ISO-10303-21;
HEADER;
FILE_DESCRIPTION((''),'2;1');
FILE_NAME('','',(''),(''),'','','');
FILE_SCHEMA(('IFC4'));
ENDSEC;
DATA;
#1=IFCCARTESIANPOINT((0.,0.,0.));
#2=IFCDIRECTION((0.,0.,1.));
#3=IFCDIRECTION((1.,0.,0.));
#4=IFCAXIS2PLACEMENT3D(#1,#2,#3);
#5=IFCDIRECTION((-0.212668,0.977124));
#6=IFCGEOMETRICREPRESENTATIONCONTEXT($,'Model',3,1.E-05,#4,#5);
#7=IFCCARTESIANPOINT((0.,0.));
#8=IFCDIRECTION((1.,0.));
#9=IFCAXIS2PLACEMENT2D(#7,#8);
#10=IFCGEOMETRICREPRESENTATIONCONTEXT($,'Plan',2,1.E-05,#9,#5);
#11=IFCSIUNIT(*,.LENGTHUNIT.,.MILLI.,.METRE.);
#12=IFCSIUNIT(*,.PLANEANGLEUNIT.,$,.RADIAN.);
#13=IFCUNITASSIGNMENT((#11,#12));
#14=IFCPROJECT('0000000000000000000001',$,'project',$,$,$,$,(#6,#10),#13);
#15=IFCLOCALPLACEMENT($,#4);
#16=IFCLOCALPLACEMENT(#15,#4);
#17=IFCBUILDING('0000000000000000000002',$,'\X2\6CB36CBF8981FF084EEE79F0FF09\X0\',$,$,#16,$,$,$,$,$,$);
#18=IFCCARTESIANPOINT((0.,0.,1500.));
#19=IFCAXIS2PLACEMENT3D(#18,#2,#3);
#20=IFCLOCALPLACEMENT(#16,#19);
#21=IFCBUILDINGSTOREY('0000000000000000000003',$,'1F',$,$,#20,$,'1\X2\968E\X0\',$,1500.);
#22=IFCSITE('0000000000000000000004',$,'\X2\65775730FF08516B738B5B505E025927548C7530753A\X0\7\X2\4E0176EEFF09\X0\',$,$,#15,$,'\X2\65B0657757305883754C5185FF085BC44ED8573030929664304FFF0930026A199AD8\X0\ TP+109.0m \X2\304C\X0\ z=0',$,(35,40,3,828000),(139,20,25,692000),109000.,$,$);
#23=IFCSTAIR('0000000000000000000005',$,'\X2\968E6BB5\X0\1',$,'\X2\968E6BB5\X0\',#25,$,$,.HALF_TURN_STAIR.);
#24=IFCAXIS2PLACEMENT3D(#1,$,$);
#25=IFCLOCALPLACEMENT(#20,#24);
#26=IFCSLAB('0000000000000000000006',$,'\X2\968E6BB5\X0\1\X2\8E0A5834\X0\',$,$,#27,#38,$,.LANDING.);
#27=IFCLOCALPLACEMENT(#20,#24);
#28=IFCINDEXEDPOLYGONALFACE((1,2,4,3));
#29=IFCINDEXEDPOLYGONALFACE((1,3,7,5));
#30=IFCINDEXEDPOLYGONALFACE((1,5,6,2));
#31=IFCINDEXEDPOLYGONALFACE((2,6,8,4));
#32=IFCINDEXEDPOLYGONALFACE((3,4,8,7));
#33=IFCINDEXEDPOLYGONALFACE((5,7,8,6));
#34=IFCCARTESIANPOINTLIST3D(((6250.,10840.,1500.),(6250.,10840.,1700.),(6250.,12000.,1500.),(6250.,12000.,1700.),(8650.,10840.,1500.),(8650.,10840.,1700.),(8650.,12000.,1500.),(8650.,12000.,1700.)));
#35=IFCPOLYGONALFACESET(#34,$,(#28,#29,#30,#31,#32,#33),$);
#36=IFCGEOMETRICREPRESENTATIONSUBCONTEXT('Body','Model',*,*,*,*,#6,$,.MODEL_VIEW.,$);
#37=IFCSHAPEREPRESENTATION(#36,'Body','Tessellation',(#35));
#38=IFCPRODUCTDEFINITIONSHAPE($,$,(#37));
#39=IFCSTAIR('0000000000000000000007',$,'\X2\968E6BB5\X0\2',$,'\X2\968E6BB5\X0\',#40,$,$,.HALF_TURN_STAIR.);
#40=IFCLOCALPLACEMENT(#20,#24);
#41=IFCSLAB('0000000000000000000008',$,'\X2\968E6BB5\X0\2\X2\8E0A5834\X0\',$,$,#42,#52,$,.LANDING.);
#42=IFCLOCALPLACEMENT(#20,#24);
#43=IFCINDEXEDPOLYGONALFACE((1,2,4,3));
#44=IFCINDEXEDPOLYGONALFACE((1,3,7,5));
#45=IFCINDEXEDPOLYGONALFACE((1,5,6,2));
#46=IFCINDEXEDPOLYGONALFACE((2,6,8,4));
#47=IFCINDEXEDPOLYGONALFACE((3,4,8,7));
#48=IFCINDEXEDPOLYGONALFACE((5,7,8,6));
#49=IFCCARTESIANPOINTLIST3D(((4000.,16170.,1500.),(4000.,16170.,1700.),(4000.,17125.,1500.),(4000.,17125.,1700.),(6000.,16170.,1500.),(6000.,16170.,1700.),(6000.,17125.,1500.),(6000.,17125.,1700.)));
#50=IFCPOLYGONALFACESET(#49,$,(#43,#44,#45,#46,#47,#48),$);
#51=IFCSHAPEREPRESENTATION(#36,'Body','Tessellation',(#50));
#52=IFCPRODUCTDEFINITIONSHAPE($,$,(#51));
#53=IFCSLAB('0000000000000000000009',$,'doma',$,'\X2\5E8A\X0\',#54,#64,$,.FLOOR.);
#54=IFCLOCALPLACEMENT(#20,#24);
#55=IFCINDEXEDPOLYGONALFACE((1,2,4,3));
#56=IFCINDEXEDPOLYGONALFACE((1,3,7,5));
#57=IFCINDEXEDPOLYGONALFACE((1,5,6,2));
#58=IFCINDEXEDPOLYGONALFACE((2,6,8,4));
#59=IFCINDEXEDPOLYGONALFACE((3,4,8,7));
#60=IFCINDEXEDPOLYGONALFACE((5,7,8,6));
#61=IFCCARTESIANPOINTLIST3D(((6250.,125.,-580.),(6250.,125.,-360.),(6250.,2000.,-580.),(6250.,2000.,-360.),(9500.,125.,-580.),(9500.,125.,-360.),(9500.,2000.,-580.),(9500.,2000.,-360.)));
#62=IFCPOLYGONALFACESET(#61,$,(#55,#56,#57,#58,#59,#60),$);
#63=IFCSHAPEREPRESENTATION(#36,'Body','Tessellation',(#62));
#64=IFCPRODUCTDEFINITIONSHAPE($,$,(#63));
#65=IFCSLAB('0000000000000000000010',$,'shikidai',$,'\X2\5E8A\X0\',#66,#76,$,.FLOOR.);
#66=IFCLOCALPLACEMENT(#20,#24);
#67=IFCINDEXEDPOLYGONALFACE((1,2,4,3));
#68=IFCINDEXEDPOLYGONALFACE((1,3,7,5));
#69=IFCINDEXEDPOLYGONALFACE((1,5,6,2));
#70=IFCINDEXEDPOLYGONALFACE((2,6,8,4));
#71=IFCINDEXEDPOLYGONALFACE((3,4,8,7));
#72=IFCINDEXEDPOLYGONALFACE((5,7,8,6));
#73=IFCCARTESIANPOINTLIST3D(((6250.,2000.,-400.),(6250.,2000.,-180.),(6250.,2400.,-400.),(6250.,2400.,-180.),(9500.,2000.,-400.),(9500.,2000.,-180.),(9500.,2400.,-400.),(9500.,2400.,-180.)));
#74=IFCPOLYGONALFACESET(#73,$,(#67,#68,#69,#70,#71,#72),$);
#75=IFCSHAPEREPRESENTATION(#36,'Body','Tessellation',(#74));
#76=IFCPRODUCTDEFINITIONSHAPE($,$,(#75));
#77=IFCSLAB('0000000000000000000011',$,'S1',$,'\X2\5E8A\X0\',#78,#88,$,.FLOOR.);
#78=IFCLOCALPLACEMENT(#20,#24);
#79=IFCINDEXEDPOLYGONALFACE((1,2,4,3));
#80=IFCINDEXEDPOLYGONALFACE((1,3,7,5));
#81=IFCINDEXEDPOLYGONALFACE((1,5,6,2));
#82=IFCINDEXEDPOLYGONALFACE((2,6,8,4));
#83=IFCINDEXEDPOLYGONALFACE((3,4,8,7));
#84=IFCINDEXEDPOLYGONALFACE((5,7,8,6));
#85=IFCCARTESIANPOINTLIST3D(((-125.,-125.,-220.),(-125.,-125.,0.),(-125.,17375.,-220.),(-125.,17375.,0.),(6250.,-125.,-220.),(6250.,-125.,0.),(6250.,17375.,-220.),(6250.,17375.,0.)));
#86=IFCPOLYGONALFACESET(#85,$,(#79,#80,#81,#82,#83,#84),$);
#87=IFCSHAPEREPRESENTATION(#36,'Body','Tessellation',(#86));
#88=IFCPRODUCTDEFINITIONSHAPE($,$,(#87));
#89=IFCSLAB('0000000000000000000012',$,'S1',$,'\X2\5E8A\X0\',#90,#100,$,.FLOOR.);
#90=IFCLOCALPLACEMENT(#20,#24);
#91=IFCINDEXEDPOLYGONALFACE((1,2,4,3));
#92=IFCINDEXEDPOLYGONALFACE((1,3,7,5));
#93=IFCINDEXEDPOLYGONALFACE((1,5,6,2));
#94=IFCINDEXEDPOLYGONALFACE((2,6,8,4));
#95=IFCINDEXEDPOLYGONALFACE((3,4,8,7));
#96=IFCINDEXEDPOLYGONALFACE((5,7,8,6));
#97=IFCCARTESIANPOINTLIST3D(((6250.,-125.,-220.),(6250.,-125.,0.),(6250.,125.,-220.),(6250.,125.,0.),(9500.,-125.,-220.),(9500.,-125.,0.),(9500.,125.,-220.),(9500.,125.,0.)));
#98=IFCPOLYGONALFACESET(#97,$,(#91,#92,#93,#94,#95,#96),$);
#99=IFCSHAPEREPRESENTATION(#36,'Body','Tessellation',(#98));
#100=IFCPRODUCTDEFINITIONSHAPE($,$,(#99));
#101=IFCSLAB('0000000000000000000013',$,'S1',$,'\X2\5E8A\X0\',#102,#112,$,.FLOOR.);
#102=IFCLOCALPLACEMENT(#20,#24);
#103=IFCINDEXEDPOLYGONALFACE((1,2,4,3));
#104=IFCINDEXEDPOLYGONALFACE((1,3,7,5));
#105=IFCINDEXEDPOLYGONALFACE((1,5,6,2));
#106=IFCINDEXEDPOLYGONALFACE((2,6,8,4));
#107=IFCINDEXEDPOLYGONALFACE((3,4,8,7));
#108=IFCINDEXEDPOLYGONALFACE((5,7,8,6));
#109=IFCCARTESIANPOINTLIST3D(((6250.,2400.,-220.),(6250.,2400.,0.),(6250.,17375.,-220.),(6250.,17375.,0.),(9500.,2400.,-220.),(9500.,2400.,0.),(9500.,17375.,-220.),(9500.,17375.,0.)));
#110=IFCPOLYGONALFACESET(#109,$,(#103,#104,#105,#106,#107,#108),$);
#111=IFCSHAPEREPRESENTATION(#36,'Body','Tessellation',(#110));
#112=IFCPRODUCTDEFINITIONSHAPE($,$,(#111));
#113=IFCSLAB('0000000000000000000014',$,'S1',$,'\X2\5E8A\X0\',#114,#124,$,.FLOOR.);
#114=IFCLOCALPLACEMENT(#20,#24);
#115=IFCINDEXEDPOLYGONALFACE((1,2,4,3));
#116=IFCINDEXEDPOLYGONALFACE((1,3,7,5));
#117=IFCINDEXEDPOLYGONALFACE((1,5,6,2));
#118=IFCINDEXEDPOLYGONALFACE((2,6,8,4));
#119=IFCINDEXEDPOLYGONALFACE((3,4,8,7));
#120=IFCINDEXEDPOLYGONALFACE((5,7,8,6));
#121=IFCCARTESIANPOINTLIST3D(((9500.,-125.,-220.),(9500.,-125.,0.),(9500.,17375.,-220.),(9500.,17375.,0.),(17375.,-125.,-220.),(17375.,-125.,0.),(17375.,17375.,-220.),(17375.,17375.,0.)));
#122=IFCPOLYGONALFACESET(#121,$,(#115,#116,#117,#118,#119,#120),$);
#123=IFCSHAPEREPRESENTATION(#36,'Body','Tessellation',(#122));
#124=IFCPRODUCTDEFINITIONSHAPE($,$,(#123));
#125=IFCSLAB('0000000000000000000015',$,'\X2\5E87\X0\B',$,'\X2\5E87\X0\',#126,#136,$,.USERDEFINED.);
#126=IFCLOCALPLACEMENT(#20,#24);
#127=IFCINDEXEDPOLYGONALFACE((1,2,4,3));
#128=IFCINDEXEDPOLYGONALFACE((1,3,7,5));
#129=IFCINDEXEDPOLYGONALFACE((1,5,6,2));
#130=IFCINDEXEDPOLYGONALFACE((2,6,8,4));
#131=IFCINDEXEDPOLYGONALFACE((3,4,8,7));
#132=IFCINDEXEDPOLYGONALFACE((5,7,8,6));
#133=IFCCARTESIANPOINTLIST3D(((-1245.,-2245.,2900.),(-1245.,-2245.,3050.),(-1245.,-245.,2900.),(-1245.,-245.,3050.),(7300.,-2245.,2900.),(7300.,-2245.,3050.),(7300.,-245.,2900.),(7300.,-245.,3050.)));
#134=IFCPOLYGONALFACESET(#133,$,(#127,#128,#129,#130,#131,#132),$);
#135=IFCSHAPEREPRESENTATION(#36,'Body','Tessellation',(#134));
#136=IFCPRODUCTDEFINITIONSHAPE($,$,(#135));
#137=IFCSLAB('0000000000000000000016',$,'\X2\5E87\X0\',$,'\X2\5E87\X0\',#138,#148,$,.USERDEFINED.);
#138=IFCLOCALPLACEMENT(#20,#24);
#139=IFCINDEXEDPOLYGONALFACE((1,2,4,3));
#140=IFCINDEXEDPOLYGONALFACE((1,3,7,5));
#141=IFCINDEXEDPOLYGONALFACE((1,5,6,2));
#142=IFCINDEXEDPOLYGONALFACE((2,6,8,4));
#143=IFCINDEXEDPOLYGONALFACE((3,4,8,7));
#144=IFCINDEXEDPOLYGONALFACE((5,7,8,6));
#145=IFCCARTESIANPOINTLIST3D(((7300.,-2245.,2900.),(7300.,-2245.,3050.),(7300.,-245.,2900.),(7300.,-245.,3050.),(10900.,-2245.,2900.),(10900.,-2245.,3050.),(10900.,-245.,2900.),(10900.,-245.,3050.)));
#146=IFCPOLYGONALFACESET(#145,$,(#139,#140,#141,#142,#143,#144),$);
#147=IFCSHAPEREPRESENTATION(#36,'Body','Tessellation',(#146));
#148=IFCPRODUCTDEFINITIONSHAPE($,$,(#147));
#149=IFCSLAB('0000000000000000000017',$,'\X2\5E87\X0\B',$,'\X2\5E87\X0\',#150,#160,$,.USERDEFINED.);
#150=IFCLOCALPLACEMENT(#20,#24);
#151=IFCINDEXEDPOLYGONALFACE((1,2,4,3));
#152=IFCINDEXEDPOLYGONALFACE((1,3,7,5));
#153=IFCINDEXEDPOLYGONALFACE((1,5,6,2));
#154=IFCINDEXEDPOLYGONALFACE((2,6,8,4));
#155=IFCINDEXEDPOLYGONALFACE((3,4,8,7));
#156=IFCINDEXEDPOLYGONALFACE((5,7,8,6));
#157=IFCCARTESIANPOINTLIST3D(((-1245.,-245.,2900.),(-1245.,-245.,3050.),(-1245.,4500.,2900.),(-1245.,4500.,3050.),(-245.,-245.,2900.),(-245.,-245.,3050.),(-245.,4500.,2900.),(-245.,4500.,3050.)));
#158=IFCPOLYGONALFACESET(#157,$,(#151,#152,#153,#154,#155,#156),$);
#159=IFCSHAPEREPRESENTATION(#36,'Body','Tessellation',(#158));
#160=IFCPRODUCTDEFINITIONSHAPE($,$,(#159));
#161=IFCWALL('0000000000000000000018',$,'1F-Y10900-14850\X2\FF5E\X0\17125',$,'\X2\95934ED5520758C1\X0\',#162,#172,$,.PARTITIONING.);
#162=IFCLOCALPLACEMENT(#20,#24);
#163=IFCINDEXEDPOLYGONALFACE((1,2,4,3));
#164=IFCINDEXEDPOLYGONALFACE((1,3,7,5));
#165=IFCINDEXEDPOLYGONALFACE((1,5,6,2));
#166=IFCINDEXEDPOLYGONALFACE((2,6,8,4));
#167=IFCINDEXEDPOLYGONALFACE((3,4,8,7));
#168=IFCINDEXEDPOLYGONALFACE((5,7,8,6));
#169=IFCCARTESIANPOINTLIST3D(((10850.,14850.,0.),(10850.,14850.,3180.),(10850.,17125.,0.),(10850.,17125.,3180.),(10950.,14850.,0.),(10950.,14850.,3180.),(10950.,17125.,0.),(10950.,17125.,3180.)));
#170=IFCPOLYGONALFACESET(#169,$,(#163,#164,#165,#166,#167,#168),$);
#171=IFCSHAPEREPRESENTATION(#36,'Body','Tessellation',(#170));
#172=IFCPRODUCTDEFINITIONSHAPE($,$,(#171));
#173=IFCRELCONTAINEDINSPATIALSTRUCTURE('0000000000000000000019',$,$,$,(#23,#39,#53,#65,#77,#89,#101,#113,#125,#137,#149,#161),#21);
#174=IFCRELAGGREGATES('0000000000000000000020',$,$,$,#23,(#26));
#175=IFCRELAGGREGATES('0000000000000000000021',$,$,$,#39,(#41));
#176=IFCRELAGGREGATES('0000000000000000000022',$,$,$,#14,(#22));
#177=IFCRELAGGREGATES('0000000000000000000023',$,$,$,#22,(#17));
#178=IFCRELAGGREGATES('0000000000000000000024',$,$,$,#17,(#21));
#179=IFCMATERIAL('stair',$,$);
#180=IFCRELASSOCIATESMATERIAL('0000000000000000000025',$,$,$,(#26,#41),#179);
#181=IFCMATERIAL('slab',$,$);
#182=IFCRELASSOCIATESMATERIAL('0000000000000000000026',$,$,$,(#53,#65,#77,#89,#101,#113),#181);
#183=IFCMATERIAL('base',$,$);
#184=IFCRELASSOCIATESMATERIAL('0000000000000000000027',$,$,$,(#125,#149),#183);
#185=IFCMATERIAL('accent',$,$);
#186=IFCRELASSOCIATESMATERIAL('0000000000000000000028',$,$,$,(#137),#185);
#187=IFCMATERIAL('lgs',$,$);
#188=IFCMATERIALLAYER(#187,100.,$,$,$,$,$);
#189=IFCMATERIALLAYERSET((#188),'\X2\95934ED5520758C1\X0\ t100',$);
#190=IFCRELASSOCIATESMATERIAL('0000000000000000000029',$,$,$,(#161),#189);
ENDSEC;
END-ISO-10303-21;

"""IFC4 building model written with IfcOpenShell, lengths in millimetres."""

from ifc_helpers import new_model, si_unit, direction, frame, frame_2d, origin, origin_with_axes, origin_2d_with_axis, place, context, subcontext, project, spatial, rectangle, extrude, material, layer, layer_set, layer_usage, element, aggregate, save


model = new_model("IFC4")

# Units and contexts
model_context = context("Model", 3, precision=1e-05, world=origin_with_axes(), true_north=direction((-0.212668, 0.977124)))
plan_context = context("Plan", 2, precision=1e-05, world=origin_2d_with_axis(), true_north=direction((-0.212668, 0.977124)))
body_context = subcontext(model_context, "Body", "Model", "MODEL_VIEW")
ifc_project = project(units=[si_unit("LENGTHUNIT", "METRE", prefix="MILLI"), si_unit("PLANEANGLEUNIT", "RADIAN")], contexts=[model_context, plan_context])

# Site, building, storey
site_placement = place(None, origin_with_axes())
site = spatial("IfcSite", under=ifc_project, at=site_placement, Name="敷地（八王子市大和田町7丁目）", LongName="新敷地境界内（寄付地を除く）。標高 TP+109.0m が z=0", RefLatitude=(35, 40, 3, 828000), RefLongitude=(139, 20, 25, 692000), RefElevation=109000.0)
building_placement = place(site_placement, origin_with_axes())
building = spatial("IfcBuilding", under=site, at=building_placement, Name="河沿要（仮称）")
storey_placement = place(building_placement, frame((0.0, 0.0, 1500.0), z_axis=(0.0, 0.0, 1.0), x_axis=(1.0, 0.0, 0.0)))
storey = spatial("IfcBuildingStorey", under=building, at=storey_placement, Name="1F", LongName="1階", Elevation=1500.0)

# Stairs, slabs
stair_1_placement = place(storey_placement, origin_with_axes())
stair_1 = element("IfcStair", 1, at=stair_1_placement, inside=storey, Name="階段1", ObjectType="階段", PredefinedType="HALF_TURN_STAIR")
ifc_material_1 = material(Name="stair")
slab_1_placement = place(stair_1_placement, origin_with_axes())
slab_1 = element("IfcSlab", 2, at=slab_1_placement, material=ifc_material_1, Name="階段1踊場", PredefinedType="LANDING", context=body_context, shape_type="SweptSolid", body=[
    extrude(rectangle(XDim=2400.0, YDim=1160.0, at=frame_2d((7450.0, 11420.0))), frame((0.0, 0.0, 1500.0)), (0.0, 0.0, 1.0), 200.0),
])
stair_2_placement = place(storey_placement, origin_with_axes())
stair_2 = element("IfcStair", 3, at=stair_2_placement, inside=storey, Name="階段2", ObjectType="階段", PredefinedType="HALF_TURN_STAIR")
slab_2_placement = place(stair_2_placement, origin_with_axes())
slab_2 = element("IfcSlab", 4, at=slab_2_placement, material=ifc_material_1, Name="階段2踊場", PredefinedType="LANDING", context=body_context, shape_type="SweptSolid", body=[
    extrude(rectangle(XDim=2000.0, YDim=955.0, at=frame_2d((5000.0, 16647.5))), frame((0.0, 0.0, 1500.0)), (0.0, 0.0, 1.0), 200.0),
])

# Slabs
ifc_material_2 = material(Name="slab")
slab_3_placement = place(storey_placement, origin_with_axes())
element("IfcSlab", 5, at=slab_3_placement, inside=storey, material=ifc_material_2, Name="doma", ObjectType="床", PredefinedType="FLOOR", context=body_context, shape_type="SweptSolid", body=[
    extrude(rectangle(XDim=3250.0, YDim=1875.0, at=frame_2d((7875.0, 1062.5))), frame((0.0, 0.0, -580.0)), (0.0, 0.0, 1.0), 220.0),
])
slab_4_placement = place(storey_placement, origin_with_axes())
element("IfcSlab", 6, at=slab_4_placement, inside=storey, material=ifc_material_2, Name="shikidai", ObjectType="床", PredefinedType="FLOOR", context=body_context, shape_type="SweptSolid", body=[
    extrude(rectangle(XDim=3250.0, YDim=400.0, at=frame_2d((7875.0, 2200.0))), frame((0.0, 0.0, -400.0)), (0.0, 0.0, 1.0), 220.0),
])
slab_5_placement = place(storey_placement, origin_with_axes())
element("IfcSlab", 7, at=slab_5_placement, inside=storey, material=ifc_material_2, Name="S1", ObjectType="床", PredefinedType="FLOOR", context=body_context, shape_type="SweptSolid", body=[
    extrude(rectangle(XDim=6375.0, YDim=17500.0, at=frame_2d((3062.5, 8625.0))), frame((0.0, 0.0, -220.0)), (0.0, 0.0, 1.0), 220.0),
])
slab_6_placement = place(storey_placement, origin_with_axes())
element("IfcSlab", 8, at=slab_6_placement, inside=storey, material=ifc_material_2, Name="S1", ObjectType="床", PredefinedType="FLOOR", context=body_context, shape_type="SweptSolid", body=[
    extrude(rectangle(XDim=3250.0, YDim=250.0, at=frame_2d((7875.0, 0.0))), frame((0.0, 0.0, -220.0)), (0.0, 0.0, 1.0), 220.0),
])
slab_7_placement = place(storey_placement, origin_with_axes())
element("IfcSlab", 9, at=slab_7_placement, inside=storey, material=ifc_material_2, Name="S1", ObjectType="床", PredefinedType="FLOOR", context=body_context, shape_type="SweptSolid", body=[
    extrude(rectangle(XDim=3250.0, YDim=14975.0, at=frame_2d((7875.0, 9887.5))), frame((0.0, 0.0, -220.0)), (0.0, 0.0, 1.0), 220.0),
])
slab_8_placement = place(storey_placement, origin_with_axes())
element("IfcSlab", 10, at=slab_8_placement, inside=storey, material=ifc_material_2, Name="S1", ObjectType="床", PredefinedType="FLOOR", context=body_context, shape_type="SweptSolid", body=[
    extrude(rectangle(XDim=7875.0, YDim=17500.0, at=frame_2d((13437.5, 8625.0))), frame((0.0, 0.0, -220.0)), (0.0, 0.0, 1.0), 220.0),
])
ifc_material_3 = material(Name="base")
slab_9_placement = place(storey_placement, origin_with_axes())
element("IfcSlab", 11, at=slab_9_placement, inside=storey, material=ifc_material_3, Name="庇B", ObjectType="庇", PredefinedType="USERDEFINED", context=body_context, shape_type="SweptSolid", body=[
    extrude(rectangle(XDim=8545.0, YDim=2000.0, at=frame_2d((3027.5, -1245.0))), frame((0.0, 0.0, 2900.0)), (0.0, 0.0, 1.0), 150.0),
])
ifc_material_4 = material(Name="accent")
slab_10_placement = place(storey_placement, origin_with_axes())
element("IfcSlab", 12, at=slab_10_placement, inside=storey, material=ifc_material_4, Name="庇", ObjectType="庇", PredefinedType="USERDEFINED", context=body_context, shape_type="SweptSolid", body=[
    extrude(rectangle(XDim=3600.0, YDim=2000.0, at=frame_2d((9100.0, -1245.0))), frame((0.0, 0.0, 2900.0)), (0.0, 0.0, 1.0), 150.0),
])
slab_11_placement = place(storey_placement, origin_with_axes())
element("IfcSlab", 13, at=slab_11_placement, inside=storey, material=ifc_material_3, Name="庇B", ObjectType="庇", PredefinedType="USERDEFINED", context=body_context, shape_type="SweptSolid", body=[
    extrude(rectangle(XDim=1000.0, YDim=4745.0, at=frame_2d((-745.0, 2127.5))), frame((0.0, 0.0, 2900.0)), (0.0, 0.0, 1.0), 150.0),
])

# Wall
ifc_material_5 = material(Name="lgs")
ifc_layer_1 = layer(ifc_material_5, 100.0)
ifc_layer_set_1 = layer_set([ifc_layer_1], Name="間仕切壁 t100")
ifc_layer_usage_1 = layer_usage(ifc_layer_set_1, "AXIS2", "POSITIVE", 0.0)
wall_1_placement = place(storey_placement, origin_with_axes())
element("IfcWall", 14, at=wall_1_placement, inside=storey, material=ifc_layer_usage_1, Name="1F-Y10900-14850～17125", ObjectType="間仕切壁", PredefinedType="PARTITIONING", context=body_context, shape_type="SweptSolid", body=[
    extrude(rectangle(XDim=100.0, YDim=2275.0, at=frame_2d((10900.0, 15987.5))), origin(), (0.0, 0.0, 1.0), 3180.0),
])

aggregate(stair_1, [slab_1])
aggregate(stair_2, [slab_2])

save(model, "model.ifc")
